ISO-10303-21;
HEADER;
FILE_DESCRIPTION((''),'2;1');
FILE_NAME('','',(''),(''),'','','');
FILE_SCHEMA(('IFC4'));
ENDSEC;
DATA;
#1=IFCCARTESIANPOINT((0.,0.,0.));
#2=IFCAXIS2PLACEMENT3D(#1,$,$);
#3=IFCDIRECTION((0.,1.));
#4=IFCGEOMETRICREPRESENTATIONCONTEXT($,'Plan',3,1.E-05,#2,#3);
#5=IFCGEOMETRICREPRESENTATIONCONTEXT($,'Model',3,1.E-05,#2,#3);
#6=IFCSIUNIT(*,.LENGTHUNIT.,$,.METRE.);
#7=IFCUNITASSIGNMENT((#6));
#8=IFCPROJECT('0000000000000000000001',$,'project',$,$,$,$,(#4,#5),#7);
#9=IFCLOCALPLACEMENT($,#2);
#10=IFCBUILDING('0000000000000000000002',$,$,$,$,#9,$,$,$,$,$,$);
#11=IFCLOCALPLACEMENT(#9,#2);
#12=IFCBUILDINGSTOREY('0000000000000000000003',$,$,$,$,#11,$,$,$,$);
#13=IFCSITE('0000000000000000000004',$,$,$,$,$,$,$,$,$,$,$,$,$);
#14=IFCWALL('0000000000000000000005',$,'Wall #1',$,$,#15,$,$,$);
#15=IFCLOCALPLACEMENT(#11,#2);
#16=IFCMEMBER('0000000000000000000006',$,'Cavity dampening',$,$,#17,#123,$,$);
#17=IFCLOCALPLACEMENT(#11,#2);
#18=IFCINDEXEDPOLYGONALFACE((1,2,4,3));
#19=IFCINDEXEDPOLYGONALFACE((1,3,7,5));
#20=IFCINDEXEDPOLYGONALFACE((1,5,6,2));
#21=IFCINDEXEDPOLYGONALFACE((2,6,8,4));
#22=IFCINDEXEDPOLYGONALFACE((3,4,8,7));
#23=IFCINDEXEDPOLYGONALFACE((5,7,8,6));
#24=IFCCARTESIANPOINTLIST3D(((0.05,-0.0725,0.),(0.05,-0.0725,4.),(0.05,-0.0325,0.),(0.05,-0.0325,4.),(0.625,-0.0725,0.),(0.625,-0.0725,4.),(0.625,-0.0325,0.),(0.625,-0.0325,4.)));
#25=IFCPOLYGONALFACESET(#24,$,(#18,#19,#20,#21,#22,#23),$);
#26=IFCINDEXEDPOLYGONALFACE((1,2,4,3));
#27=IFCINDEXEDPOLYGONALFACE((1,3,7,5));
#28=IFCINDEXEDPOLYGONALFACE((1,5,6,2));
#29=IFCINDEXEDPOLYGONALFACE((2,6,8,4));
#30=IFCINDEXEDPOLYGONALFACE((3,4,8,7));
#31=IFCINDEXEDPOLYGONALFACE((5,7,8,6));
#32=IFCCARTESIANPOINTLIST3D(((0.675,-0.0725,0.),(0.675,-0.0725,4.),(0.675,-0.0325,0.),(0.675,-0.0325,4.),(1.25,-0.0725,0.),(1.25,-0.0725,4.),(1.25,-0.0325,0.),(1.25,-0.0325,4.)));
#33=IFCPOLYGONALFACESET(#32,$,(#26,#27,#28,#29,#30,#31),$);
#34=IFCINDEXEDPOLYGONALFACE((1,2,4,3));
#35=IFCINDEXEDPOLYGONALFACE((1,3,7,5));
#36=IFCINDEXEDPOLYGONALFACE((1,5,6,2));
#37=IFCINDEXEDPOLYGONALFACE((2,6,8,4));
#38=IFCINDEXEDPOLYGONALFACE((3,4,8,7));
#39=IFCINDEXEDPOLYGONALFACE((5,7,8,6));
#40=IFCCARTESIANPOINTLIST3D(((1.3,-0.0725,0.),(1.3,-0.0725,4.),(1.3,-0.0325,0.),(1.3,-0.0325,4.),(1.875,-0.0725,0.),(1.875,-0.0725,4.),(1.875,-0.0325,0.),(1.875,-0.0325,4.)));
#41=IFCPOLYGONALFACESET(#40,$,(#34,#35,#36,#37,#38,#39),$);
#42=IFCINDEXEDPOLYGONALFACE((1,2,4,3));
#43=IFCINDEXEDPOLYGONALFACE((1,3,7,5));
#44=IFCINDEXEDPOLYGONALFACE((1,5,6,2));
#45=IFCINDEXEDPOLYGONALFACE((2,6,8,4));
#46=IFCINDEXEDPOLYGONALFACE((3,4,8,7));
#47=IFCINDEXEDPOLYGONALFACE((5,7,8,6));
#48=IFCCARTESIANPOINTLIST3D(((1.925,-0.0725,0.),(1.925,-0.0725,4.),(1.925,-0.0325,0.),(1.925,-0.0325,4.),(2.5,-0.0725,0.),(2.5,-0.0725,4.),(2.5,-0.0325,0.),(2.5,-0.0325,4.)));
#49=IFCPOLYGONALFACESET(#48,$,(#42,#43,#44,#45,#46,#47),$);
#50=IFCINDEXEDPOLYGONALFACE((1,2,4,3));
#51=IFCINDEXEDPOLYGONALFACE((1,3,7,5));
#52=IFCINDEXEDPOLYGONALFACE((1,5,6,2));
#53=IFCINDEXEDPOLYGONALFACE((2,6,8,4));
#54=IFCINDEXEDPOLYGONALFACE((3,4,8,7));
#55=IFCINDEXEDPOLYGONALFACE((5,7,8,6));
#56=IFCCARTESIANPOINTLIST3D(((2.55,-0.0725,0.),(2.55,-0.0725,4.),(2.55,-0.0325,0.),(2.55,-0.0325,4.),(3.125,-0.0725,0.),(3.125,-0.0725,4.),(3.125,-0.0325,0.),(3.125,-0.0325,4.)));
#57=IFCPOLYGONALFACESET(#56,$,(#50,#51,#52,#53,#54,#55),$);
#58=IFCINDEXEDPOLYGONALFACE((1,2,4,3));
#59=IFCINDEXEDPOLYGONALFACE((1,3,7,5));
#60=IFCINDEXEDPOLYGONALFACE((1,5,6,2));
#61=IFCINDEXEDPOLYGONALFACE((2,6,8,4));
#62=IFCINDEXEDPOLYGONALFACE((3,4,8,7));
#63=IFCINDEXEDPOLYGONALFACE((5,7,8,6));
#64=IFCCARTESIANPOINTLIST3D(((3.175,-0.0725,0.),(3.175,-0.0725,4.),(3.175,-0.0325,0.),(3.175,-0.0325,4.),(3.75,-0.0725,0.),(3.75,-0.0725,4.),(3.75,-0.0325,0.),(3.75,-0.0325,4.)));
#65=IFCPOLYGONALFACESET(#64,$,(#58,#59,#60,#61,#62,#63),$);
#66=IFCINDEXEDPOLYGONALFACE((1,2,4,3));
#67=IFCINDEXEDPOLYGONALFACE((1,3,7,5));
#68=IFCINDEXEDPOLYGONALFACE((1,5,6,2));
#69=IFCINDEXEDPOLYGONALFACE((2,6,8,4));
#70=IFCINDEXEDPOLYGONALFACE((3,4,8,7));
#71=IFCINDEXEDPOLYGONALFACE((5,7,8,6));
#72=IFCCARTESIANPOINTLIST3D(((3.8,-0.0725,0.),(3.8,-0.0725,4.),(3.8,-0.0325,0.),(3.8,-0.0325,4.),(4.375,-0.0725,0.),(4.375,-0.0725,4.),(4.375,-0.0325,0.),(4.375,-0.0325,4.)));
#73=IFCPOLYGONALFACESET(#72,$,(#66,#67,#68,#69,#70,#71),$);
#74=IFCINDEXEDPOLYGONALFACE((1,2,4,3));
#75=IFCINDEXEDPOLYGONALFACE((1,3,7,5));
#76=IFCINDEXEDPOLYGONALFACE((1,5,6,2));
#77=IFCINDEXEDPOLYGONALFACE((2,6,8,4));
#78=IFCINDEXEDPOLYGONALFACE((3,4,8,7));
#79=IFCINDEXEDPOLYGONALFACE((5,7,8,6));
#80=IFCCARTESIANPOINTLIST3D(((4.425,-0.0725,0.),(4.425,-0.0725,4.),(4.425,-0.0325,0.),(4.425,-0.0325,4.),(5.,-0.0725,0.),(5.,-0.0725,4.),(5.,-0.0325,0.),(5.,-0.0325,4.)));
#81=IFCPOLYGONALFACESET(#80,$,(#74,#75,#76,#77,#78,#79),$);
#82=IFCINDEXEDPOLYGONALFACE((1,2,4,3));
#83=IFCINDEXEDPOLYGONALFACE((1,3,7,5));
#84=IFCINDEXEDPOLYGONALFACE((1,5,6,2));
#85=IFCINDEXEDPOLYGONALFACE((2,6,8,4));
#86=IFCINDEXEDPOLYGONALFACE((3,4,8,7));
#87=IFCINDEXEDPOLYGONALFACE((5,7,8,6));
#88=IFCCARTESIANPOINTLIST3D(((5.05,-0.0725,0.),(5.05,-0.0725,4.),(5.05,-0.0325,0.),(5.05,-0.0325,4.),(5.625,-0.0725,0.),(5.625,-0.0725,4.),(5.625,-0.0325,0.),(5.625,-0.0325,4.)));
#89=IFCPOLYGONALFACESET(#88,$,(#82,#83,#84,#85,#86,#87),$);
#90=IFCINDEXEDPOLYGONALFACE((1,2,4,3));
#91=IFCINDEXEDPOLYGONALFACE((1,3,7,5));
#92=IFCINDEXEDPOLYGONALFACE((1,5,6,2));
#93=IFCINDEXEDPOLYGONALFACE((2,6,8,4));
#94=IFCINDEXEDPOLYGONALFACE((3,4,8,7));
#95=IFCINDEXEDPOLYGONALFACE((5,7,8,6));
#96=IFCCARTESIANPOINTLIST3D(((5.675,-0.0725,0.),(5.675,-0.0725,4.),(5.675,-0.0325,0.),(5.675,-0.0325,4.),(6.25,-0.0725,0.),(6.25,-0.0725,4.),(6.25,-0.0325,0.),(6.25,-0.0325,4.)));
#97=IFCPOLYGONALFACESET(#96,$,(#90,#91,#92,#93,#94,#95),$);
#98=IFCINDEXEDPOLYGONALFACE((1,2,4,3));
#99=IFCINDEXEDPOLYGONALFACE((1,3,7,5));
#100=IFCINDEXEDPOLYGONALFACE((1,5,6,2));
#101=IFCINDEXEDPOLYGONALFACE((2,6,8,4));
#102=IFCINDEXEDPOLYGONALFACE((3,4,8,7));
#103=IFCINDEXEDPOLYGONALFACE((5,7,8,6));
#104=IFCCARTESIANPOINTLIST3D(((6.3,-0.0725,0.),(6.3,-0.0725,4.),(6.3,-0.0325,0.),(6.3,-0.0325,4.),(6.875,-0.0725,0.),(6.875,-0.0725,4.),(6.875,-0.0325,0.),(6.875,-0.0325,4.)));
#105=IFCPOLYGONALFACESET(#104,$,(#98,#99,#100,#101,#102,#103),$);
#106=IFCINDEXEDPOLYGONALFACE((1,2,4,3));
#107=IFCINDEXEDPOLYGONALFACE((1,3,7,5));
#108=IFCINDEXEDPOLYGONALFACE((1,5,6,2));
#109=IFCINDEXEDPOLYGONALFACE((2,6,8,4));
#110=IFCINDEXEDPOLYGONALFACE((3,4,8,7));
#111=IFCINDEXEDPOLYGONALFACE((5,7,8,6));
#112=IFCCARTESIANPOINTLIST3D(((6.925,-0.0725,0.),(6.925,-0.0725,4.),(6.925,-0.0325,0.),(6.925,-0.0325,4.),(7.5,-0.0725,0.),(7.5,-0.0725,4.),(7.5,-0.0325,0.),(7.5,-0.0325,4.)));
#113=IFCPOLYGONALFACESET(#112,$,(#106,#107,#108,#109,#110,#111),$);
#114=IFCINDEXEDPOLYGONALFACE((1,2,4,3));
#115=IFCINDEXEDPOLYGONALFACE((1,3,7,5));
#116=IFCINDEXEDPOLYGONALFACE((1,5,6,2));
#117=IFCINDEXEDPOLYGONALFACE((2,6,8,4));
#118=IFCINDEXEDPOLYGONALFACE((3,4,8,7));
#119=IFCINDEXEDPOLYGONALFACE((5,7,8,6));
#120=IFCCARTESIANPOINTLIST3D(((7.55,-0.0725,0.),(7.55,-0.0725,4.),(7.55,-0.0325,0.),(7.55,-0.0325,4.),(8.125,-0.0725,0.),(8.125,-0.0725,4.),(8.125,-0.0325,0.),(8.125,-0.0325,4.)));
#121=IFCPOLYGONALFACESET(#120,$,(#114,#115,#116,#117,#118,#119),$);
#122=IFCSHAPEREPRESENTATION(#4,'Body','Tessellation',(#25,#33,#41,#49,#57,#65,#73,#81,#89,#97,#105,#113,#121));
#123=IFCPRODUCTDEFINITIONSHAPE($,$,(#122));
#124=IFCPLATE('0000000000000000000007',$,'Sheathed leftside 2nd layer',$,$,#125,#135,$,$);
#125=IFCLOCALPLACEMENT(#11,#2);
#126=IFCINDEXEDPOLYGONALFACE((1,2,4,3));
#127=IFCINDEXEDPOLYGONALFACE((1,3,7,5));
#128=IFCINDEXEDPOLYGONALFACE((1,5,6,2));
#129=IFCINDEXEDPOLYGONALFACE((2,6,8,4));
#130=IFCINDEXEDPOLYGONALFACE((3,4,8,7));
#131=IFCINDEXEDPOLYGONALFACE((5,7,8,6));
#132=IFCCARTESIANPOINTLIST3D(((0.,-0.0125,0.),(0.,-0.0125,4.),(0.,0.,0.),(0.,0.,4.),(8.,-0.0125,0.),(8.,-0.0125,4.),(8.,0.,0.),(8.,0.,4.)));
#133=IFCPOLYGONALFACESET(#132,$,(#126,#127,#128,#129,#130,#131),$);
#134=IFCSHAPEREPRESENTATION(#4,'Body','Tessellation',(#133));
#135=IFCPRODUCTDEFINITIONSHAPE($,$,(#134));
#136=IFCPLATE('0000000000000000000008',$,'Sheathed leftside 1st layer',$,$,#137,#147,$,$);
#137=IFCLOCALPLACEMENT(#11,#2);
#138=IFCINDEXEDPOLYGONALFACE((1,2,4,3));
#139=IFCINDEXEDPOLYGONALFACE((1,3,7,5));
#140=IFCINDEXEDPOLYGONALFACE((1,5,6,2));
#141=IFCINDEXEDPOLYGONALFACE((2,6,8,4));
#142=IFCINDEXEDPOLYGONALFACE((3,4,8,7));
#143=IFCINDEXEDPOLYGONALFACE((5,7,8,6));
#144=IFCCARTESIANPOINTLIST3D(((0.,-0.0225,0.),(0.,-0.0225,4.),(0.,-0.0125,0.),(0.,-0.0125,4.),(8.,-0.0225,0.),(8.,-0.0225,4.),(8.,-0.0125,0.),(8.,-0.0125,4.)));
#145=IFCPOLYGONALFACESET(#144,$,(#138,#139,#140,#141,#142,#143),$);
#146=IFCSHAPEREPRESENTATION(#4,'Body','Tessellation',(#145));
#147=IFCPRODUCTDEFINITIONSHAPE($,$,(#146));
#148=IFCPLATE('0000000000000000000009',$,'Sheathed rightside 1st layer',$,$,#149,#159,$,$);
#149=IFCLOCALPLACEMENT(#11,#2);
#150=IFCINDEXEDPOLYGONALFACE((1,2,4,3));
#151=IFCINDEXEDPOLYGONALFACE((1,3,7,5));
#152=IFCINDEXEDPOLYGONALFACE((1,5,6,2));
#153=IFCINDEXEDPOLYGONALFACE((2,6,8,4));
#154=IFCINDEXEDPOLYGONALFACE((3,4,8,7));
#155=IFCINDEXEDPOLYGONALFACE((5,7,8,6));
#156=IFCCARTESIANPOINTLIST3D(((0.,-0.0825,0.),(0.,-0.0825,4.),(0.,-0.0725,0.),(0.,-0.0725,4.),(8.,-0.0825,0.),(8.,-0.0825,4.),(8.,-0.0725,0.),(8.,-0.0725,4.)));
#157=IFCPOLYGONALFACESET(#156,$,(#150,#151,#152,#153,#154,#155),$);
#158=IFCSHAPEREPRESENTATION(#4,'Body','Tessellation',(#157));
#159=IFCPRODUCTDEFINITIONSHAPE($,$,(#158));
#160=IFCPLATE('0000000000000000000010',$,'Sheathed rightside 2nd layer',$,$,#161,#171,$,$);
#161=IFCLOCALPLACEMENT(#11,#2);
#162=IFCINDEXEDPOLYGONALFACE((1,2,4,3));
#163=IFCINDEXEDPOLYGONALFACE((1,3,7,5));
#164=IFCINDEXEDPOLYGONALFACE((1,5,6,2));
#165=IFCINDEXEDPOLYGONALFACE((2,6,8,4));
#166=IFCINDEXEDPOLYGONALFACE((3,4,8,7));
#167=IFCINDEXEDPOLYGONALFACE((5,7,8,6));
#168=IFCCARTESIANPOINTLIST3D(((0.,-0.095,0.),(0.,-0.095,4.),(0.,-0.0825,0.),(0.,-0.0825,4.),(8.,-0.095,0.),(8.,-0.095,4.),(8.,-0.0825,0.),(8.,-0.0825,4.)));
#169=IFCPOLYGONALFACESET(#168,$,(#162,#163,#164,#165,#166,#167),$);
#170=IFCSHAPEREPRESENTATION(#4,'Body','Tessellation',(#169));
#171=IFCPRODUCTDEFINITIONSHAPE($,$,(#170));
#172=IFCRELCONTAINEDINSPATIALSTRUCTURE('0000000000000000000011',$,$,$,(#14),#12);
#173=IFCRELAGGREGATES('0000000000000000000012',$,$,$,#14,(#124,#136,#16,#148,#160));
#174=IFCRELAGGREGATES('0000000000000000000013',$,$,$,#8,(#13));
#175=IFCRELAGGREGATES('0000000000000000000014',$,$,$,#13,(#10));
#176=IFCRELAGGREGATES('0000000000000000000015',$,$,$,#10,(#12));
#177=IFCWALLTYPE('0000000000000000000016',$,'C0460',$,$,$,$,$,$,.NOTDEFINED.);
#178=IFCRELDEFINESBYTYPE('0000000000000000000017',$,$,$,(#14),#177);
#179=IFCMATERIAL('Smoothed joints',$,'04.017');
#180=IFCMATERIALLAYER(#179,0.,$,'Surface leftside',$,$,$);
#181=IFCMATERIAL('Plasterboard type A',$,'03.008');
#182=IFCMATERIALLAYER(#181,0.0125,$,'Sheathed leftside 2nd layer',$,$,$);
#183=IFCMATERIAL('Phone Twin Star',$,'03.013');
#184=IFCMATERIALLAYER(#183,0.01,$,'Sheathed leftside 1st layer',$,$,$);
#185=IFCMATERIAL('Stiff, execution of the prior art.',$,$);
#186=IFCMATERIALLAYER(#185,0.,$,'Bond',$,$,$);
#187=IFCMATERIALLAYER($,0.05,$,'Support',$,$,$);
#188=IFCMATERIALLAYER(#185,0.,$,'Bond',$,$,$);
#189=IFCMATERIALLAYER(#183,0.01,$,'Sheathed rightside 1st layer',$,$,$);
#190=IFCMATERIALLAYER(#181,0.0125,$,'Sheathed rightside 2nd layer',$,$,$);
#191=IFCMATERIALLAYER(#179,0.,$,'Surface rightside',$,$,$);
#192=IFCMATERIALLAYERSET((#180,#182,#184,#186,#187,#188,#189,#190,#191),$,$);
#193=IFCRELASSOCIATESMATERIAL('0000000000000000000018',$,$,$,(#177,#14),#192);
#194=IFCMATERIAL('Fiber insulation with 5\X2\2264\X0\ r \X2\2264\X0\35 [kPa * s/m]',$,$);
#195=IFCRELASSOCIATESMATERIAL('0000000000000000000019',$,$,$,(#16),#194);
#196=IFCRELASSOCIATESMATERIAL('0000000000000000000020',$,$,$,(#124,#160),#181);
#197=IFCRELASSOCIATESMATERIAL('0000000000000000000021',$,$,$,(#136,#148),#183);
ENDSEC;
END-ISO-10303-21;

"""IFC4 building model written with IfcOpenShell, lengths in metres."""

from ifc_helpers import new_model, si_unit, direction, frame, frame_2d, origin, origin_with_axes, place, context, project, spatial, rectangle, extrude, material, layer, layer_set, type_object, element, aggregate, save


model = new_model("IFC4")

# Units and contexts
plan_context = context("Plan", 3, precision=1e-05, world=origin(), true_north=direction((0.0, 1.0)))
model_context = context("Model", 3, precision=1e-05, world=origin(), true_north=direction((0.0, 1.0)))
ifc_project = project(units=[si_unit("LENGTHUNIT", "METRE")], contexts=[plan_context, model_context])

# Site, building, storey
site = spatial("IfcSite", under=ifc_project)
building_placement = place(None, origin())
building = spatial("IfcBuilding", under=site, at=building_placement)
storey_placement = place(building_placement, origin())
storey = spatial("IfcBuildingStorey", under=building, at=storey_placement)

# Wall, member, plates
ifc_material_1 = material(Name="Smoothed joints", Category="04.017")
ifc_layer_1 = layer(ifc_material_1, 0.0, Name="Surface leftside")
ifc_material_2 = material(Name="Plasterboard type A", Category="03.008")
ifc_layer_2 = layer(ifc_material_2, 0.0125, Name="Sheathed leftside 2nd layer")
ifc_material_3 = material(Name="Phone Twin Star", Category="03.013")
ifc_layer_3 = layer(ifc_material_3, 0.01, Name="Sheathed leftside 1st layer")
ifc_material_4 = material(Name="Stiff, execution of the prior art.")
ifc_layer_4 = layer(ifc_material_4, 0.0, Name="Bond")
ifc_layer_5 = layer(None, 0.05, Name="Support")
ifc_layer_6 = layer(ifc_material_4, 0.0, Name="Bond")
ifc_layer_7 = layer(ifc_material_3, 0.01, Name="Sheathed rightside 1st layer")
ifc_layer_8 = layer(ifc_material_2, 0.0125, Name="Sheathed rightside 2nd layer")
ifc_layer_9 = layer(ifc_material_1, 0.0, Name="Surface rightside")
ifc_layer_set = layer_set([ifc_layer_1, ifc_layer_2, ifc_layer_3, ifc_layer_4, ifc_layer_5, ifc_layer_6, ifc_layer_7, ifc_layer_8, ifc_layer_9])
wall_type = type_object("IfcWallType", Name="C0460", PredefinedType="NOTDEFINED", material=ifc_layer_set)
wall_placement = place(None, frame((0.0, 0.0, 0.0), z_axis=(0.0, -1.0, 0.0), x_axis=(1.0, 0.0, 0.0)))
wall = element("IfcWall", 1, at=wall_placement, inside=storey, type_object=wall_type, material=ifc_layer_set, Name="Wall #1")
ifc_material_5 = material(Name="Fiber insulation with 5≤ r ≤35 [kPa * s/m]")
member_1_placement = place(wall_placement, origin())
member_1 = element("IfcMember", 2, at=member_1_placement, material=ifc_material_5, Name="Cavity dampening", context=plan_context, shape_type="SweptSolid", body=[
    extrude(rectangle(XDim=0.575, YDim=0.04, at=frame_2d((0.2875, 0.02), x_axis=(1.0, 0.0))), frame((0.05, 4.0, 0.0325), z_axis=(0.0, -1.0, 0.0), x_axis=(1.0, 0.0, 0.0)), (0.0, 0.0, 1.0), 4.0),
    extrude(rectangle(XDim=0.575, YDim=0.04, at=frame_2d((0.2875, 0.02), x_axis=(1.0, 0.0))), frame((0.675, 4.0, 0.0325), z_axis=(0.0, -1.0, 0.0), x_axis=(1.0, 0.0, 0.0)), (0.0, 0.0, 1.0), 4.0),
    extrude(rectangle(XDim=0.575, YDim=0.04, at=frame_2d((0.2875, 0.02), x_axis=(1.0, 0.0))), frame((1.3, 4.0, 0.0325), z_axis=(0.0, -1.0, 0.0), x_axis=(1.0, 0.0, 0.0)), (0.0, 0.0, 1.0), 4.0),
    extrude(rectangle(XDim=0.575, YDim=0.04, at=frame_2d((0.2875, 0.02), x_axis=(1.0, 0.0))), frame((1.925, 4.0, 0.0325), z_axis=(0.0, -1.0, 0.0), x_axis=(1.0, 0.0, 0.0)), (0.0, 0.0, 1.0), 4.0),
    extrude(rectangle(XDim=0.575, YDim=0.04, at=frame_2d((0.2875, 0.02), x_axis=(1.0, 0.0))), frame((2.55, 4.0, 0.0325), z_axis=(0.0, -1.0, 0.0), x_axis=(1.0, 0.0, 0.0)), (0.0, 0.0, 1.0), 4.0),
    extrude(rectangle(XDim=0.575, YDim=0.04, at=frame_2d((0.2875, 0.02), x_axis=(1.0, 0.0))), frame((3.175, 4.0, 0.0325), z_axis=(0.0, -1.0, 0.0), x_axis=(1.0, 0.0, 0.0)), (0.0, 0.0, 1.0), 4.0),
    extrude(rectangle(XDim=0.575, YDim=0.04, at=frame_2d((0.2875, 0.02), x_axis=(1.0, 0.0))), frame((3.8, 4.0, 0.0325), z_axis=(0.0, -1.0, 0.0), x_axis=(1.0, 0.0, 0.0)), (0.0, 0.0, 1.0), 4.0),
    extrude(rectangle(XDim=0.575, YDim=0.04, at=frame_2d((0.2875, 0.02), x_axis=(1.0, 0.0))), frame((4.425, 4.0, 0.0325), z_axis=(0.0, -1.0, 0.0), x_axis=(1.0, 0.0, 0.0)), (0.0, 0.0, 1.0), 4.0),
    extrude(rectangle(XDim=0.575, YDim=0.04, at=frame_2d((0.2875, 0.02), x_axis=(1.0, 0.0))), frame((5.05, 4.0, 0.0325), z_axis=(0.0, -1.0, 0.0), x_axis=(1.0, 0.0, 0.0)), (0.0, 0.0, 1.0), 4.0),
    extrude(rectangle(XDim=0.575, YDim=0.04, at=frame_2d((0.2875, 0.02), x_axis=(1.0, 0.0))), frame((5.675, 4.0, 0.0325), z_axis=(0.0, -1.0, 0.0), x_axis=(1.0, 0.0, 0.0)), (0.0, 0.0, 1.0), 4.0),
    extrude(rectangle(XDim=0.575, YDim=0.04, at=frame_2d((0.2875, 0.02), x_axis=(1.0, 0.0))), frame((6.3, 4.0, 0.0325), z_axis=(0.0, -1.0, 0.0), x_axis=(1.0, 0.0, 0.0)), (0.0, 0.0, 1.0), 4.0),
    extrude(rectangle(XDim=0.575, YDim=0.04, at=frame_2d((0.2875, 0.02), x_axis=(1.0, 0.0))), frame((6.925, 4.0, 0.0325), z_axis=(0.0, -1.0, 0.0), x_axis=(1.0, 0.0, 0.0)), (0.0, 0.0, 1.0), 4.0),
    extrude(rectangle(XDim=0.575, YDim=0.04, at=frame_2d((0.2875, 0.02), x_axis=(1.0, 0.0))), frame((7.55, 4.0, 0.0325), z_axis=(0.0, -1.0, 0.0), x_axis=(1.0, 0.0, 0.0)), (0.0, 0.0, 1.0), 4.0),
])
plate_1_placement = place(wall_placement, origin())
plate_1 = element("IfcPlate", 3, at=plate_1_placement, material=ifc_material_2, Name="Sheathed leftside 2nd layer", context=plan_context, shape_type="SweptSolid", body=[
    extrude(rectangle(XDim=8.0, YDim=4.0, at=frame_2d((4.0, 2.0), x_axis=(1.0, 0.0))), origin_with_axes(), (0.0, 0.0, 1.0), 0.0125),
])
plate_2_placement = place(wall_placement, origin())
plate_2 = element("IfcPlate", 4, at=plate_2_placement, material=ifc_material_3, Name="Sheathed leftside 1st layer", context=plan_context, shape_type="SweptSolid", body=[
    extrude(rectangle(XDim=8.0, YDim=4.0, at=frame_2d((4.0, 2.0), x_axis=(1.0, 0.0))), frame((0.0, 0.0, 0.0125), z_axis=(0.0, 0.0, 1.0), x_axis=(1.0, 0.0, 0.0)), (0.0, 0.0, 1.0), 0.01),
])
plate_3_placement = place(wall_placement, origin())
plate_3 = element("IfcPlate", 5, at=plate_3_placement, material=ifc_material_3, Name="Sheathed rightside 1st layer", context=plan_context, shape_type="SweptSolid", body=[
    extrude(rectangle(XDim=8.0, YDim=4.0, at=frame_2d((4.0, 2.0), x_axis=(1.0, 0.0))), frame((0.0, 0.0, 0.0725), z_axis=(0.0, 0.0, 1.0), x_axis=(1.0, 0.0, 0.0)), (0.0, 0.0, 1.0), 0.01),
])
plate_4_placement = place(wall_placement, origin())
plate_4 = element("IfcPlate", 6, at=plate_4_placement, material=ifc_material_2, Name="Sheathed rightside 2nd layer", context=plan_context, shape_type="SweptSolid", body=[
    extrude(rectangle(XDim=8.0, YDim=4.0, at=frame_2d((4.0, 2.0), x_axis=(1.0, 0.0))), frame((0.0, 0.0, 0.0825), z_axis=(0.0, 0.0, 1.0), x_axis=(1.0, 0.0, 0.0)), (0.0, 0.0, 1.0), 0.0125),
])
aggregate(wall, [plate_1, plate_2, member_1, plate_3, plate_4])

save(model, "model.ifc")
